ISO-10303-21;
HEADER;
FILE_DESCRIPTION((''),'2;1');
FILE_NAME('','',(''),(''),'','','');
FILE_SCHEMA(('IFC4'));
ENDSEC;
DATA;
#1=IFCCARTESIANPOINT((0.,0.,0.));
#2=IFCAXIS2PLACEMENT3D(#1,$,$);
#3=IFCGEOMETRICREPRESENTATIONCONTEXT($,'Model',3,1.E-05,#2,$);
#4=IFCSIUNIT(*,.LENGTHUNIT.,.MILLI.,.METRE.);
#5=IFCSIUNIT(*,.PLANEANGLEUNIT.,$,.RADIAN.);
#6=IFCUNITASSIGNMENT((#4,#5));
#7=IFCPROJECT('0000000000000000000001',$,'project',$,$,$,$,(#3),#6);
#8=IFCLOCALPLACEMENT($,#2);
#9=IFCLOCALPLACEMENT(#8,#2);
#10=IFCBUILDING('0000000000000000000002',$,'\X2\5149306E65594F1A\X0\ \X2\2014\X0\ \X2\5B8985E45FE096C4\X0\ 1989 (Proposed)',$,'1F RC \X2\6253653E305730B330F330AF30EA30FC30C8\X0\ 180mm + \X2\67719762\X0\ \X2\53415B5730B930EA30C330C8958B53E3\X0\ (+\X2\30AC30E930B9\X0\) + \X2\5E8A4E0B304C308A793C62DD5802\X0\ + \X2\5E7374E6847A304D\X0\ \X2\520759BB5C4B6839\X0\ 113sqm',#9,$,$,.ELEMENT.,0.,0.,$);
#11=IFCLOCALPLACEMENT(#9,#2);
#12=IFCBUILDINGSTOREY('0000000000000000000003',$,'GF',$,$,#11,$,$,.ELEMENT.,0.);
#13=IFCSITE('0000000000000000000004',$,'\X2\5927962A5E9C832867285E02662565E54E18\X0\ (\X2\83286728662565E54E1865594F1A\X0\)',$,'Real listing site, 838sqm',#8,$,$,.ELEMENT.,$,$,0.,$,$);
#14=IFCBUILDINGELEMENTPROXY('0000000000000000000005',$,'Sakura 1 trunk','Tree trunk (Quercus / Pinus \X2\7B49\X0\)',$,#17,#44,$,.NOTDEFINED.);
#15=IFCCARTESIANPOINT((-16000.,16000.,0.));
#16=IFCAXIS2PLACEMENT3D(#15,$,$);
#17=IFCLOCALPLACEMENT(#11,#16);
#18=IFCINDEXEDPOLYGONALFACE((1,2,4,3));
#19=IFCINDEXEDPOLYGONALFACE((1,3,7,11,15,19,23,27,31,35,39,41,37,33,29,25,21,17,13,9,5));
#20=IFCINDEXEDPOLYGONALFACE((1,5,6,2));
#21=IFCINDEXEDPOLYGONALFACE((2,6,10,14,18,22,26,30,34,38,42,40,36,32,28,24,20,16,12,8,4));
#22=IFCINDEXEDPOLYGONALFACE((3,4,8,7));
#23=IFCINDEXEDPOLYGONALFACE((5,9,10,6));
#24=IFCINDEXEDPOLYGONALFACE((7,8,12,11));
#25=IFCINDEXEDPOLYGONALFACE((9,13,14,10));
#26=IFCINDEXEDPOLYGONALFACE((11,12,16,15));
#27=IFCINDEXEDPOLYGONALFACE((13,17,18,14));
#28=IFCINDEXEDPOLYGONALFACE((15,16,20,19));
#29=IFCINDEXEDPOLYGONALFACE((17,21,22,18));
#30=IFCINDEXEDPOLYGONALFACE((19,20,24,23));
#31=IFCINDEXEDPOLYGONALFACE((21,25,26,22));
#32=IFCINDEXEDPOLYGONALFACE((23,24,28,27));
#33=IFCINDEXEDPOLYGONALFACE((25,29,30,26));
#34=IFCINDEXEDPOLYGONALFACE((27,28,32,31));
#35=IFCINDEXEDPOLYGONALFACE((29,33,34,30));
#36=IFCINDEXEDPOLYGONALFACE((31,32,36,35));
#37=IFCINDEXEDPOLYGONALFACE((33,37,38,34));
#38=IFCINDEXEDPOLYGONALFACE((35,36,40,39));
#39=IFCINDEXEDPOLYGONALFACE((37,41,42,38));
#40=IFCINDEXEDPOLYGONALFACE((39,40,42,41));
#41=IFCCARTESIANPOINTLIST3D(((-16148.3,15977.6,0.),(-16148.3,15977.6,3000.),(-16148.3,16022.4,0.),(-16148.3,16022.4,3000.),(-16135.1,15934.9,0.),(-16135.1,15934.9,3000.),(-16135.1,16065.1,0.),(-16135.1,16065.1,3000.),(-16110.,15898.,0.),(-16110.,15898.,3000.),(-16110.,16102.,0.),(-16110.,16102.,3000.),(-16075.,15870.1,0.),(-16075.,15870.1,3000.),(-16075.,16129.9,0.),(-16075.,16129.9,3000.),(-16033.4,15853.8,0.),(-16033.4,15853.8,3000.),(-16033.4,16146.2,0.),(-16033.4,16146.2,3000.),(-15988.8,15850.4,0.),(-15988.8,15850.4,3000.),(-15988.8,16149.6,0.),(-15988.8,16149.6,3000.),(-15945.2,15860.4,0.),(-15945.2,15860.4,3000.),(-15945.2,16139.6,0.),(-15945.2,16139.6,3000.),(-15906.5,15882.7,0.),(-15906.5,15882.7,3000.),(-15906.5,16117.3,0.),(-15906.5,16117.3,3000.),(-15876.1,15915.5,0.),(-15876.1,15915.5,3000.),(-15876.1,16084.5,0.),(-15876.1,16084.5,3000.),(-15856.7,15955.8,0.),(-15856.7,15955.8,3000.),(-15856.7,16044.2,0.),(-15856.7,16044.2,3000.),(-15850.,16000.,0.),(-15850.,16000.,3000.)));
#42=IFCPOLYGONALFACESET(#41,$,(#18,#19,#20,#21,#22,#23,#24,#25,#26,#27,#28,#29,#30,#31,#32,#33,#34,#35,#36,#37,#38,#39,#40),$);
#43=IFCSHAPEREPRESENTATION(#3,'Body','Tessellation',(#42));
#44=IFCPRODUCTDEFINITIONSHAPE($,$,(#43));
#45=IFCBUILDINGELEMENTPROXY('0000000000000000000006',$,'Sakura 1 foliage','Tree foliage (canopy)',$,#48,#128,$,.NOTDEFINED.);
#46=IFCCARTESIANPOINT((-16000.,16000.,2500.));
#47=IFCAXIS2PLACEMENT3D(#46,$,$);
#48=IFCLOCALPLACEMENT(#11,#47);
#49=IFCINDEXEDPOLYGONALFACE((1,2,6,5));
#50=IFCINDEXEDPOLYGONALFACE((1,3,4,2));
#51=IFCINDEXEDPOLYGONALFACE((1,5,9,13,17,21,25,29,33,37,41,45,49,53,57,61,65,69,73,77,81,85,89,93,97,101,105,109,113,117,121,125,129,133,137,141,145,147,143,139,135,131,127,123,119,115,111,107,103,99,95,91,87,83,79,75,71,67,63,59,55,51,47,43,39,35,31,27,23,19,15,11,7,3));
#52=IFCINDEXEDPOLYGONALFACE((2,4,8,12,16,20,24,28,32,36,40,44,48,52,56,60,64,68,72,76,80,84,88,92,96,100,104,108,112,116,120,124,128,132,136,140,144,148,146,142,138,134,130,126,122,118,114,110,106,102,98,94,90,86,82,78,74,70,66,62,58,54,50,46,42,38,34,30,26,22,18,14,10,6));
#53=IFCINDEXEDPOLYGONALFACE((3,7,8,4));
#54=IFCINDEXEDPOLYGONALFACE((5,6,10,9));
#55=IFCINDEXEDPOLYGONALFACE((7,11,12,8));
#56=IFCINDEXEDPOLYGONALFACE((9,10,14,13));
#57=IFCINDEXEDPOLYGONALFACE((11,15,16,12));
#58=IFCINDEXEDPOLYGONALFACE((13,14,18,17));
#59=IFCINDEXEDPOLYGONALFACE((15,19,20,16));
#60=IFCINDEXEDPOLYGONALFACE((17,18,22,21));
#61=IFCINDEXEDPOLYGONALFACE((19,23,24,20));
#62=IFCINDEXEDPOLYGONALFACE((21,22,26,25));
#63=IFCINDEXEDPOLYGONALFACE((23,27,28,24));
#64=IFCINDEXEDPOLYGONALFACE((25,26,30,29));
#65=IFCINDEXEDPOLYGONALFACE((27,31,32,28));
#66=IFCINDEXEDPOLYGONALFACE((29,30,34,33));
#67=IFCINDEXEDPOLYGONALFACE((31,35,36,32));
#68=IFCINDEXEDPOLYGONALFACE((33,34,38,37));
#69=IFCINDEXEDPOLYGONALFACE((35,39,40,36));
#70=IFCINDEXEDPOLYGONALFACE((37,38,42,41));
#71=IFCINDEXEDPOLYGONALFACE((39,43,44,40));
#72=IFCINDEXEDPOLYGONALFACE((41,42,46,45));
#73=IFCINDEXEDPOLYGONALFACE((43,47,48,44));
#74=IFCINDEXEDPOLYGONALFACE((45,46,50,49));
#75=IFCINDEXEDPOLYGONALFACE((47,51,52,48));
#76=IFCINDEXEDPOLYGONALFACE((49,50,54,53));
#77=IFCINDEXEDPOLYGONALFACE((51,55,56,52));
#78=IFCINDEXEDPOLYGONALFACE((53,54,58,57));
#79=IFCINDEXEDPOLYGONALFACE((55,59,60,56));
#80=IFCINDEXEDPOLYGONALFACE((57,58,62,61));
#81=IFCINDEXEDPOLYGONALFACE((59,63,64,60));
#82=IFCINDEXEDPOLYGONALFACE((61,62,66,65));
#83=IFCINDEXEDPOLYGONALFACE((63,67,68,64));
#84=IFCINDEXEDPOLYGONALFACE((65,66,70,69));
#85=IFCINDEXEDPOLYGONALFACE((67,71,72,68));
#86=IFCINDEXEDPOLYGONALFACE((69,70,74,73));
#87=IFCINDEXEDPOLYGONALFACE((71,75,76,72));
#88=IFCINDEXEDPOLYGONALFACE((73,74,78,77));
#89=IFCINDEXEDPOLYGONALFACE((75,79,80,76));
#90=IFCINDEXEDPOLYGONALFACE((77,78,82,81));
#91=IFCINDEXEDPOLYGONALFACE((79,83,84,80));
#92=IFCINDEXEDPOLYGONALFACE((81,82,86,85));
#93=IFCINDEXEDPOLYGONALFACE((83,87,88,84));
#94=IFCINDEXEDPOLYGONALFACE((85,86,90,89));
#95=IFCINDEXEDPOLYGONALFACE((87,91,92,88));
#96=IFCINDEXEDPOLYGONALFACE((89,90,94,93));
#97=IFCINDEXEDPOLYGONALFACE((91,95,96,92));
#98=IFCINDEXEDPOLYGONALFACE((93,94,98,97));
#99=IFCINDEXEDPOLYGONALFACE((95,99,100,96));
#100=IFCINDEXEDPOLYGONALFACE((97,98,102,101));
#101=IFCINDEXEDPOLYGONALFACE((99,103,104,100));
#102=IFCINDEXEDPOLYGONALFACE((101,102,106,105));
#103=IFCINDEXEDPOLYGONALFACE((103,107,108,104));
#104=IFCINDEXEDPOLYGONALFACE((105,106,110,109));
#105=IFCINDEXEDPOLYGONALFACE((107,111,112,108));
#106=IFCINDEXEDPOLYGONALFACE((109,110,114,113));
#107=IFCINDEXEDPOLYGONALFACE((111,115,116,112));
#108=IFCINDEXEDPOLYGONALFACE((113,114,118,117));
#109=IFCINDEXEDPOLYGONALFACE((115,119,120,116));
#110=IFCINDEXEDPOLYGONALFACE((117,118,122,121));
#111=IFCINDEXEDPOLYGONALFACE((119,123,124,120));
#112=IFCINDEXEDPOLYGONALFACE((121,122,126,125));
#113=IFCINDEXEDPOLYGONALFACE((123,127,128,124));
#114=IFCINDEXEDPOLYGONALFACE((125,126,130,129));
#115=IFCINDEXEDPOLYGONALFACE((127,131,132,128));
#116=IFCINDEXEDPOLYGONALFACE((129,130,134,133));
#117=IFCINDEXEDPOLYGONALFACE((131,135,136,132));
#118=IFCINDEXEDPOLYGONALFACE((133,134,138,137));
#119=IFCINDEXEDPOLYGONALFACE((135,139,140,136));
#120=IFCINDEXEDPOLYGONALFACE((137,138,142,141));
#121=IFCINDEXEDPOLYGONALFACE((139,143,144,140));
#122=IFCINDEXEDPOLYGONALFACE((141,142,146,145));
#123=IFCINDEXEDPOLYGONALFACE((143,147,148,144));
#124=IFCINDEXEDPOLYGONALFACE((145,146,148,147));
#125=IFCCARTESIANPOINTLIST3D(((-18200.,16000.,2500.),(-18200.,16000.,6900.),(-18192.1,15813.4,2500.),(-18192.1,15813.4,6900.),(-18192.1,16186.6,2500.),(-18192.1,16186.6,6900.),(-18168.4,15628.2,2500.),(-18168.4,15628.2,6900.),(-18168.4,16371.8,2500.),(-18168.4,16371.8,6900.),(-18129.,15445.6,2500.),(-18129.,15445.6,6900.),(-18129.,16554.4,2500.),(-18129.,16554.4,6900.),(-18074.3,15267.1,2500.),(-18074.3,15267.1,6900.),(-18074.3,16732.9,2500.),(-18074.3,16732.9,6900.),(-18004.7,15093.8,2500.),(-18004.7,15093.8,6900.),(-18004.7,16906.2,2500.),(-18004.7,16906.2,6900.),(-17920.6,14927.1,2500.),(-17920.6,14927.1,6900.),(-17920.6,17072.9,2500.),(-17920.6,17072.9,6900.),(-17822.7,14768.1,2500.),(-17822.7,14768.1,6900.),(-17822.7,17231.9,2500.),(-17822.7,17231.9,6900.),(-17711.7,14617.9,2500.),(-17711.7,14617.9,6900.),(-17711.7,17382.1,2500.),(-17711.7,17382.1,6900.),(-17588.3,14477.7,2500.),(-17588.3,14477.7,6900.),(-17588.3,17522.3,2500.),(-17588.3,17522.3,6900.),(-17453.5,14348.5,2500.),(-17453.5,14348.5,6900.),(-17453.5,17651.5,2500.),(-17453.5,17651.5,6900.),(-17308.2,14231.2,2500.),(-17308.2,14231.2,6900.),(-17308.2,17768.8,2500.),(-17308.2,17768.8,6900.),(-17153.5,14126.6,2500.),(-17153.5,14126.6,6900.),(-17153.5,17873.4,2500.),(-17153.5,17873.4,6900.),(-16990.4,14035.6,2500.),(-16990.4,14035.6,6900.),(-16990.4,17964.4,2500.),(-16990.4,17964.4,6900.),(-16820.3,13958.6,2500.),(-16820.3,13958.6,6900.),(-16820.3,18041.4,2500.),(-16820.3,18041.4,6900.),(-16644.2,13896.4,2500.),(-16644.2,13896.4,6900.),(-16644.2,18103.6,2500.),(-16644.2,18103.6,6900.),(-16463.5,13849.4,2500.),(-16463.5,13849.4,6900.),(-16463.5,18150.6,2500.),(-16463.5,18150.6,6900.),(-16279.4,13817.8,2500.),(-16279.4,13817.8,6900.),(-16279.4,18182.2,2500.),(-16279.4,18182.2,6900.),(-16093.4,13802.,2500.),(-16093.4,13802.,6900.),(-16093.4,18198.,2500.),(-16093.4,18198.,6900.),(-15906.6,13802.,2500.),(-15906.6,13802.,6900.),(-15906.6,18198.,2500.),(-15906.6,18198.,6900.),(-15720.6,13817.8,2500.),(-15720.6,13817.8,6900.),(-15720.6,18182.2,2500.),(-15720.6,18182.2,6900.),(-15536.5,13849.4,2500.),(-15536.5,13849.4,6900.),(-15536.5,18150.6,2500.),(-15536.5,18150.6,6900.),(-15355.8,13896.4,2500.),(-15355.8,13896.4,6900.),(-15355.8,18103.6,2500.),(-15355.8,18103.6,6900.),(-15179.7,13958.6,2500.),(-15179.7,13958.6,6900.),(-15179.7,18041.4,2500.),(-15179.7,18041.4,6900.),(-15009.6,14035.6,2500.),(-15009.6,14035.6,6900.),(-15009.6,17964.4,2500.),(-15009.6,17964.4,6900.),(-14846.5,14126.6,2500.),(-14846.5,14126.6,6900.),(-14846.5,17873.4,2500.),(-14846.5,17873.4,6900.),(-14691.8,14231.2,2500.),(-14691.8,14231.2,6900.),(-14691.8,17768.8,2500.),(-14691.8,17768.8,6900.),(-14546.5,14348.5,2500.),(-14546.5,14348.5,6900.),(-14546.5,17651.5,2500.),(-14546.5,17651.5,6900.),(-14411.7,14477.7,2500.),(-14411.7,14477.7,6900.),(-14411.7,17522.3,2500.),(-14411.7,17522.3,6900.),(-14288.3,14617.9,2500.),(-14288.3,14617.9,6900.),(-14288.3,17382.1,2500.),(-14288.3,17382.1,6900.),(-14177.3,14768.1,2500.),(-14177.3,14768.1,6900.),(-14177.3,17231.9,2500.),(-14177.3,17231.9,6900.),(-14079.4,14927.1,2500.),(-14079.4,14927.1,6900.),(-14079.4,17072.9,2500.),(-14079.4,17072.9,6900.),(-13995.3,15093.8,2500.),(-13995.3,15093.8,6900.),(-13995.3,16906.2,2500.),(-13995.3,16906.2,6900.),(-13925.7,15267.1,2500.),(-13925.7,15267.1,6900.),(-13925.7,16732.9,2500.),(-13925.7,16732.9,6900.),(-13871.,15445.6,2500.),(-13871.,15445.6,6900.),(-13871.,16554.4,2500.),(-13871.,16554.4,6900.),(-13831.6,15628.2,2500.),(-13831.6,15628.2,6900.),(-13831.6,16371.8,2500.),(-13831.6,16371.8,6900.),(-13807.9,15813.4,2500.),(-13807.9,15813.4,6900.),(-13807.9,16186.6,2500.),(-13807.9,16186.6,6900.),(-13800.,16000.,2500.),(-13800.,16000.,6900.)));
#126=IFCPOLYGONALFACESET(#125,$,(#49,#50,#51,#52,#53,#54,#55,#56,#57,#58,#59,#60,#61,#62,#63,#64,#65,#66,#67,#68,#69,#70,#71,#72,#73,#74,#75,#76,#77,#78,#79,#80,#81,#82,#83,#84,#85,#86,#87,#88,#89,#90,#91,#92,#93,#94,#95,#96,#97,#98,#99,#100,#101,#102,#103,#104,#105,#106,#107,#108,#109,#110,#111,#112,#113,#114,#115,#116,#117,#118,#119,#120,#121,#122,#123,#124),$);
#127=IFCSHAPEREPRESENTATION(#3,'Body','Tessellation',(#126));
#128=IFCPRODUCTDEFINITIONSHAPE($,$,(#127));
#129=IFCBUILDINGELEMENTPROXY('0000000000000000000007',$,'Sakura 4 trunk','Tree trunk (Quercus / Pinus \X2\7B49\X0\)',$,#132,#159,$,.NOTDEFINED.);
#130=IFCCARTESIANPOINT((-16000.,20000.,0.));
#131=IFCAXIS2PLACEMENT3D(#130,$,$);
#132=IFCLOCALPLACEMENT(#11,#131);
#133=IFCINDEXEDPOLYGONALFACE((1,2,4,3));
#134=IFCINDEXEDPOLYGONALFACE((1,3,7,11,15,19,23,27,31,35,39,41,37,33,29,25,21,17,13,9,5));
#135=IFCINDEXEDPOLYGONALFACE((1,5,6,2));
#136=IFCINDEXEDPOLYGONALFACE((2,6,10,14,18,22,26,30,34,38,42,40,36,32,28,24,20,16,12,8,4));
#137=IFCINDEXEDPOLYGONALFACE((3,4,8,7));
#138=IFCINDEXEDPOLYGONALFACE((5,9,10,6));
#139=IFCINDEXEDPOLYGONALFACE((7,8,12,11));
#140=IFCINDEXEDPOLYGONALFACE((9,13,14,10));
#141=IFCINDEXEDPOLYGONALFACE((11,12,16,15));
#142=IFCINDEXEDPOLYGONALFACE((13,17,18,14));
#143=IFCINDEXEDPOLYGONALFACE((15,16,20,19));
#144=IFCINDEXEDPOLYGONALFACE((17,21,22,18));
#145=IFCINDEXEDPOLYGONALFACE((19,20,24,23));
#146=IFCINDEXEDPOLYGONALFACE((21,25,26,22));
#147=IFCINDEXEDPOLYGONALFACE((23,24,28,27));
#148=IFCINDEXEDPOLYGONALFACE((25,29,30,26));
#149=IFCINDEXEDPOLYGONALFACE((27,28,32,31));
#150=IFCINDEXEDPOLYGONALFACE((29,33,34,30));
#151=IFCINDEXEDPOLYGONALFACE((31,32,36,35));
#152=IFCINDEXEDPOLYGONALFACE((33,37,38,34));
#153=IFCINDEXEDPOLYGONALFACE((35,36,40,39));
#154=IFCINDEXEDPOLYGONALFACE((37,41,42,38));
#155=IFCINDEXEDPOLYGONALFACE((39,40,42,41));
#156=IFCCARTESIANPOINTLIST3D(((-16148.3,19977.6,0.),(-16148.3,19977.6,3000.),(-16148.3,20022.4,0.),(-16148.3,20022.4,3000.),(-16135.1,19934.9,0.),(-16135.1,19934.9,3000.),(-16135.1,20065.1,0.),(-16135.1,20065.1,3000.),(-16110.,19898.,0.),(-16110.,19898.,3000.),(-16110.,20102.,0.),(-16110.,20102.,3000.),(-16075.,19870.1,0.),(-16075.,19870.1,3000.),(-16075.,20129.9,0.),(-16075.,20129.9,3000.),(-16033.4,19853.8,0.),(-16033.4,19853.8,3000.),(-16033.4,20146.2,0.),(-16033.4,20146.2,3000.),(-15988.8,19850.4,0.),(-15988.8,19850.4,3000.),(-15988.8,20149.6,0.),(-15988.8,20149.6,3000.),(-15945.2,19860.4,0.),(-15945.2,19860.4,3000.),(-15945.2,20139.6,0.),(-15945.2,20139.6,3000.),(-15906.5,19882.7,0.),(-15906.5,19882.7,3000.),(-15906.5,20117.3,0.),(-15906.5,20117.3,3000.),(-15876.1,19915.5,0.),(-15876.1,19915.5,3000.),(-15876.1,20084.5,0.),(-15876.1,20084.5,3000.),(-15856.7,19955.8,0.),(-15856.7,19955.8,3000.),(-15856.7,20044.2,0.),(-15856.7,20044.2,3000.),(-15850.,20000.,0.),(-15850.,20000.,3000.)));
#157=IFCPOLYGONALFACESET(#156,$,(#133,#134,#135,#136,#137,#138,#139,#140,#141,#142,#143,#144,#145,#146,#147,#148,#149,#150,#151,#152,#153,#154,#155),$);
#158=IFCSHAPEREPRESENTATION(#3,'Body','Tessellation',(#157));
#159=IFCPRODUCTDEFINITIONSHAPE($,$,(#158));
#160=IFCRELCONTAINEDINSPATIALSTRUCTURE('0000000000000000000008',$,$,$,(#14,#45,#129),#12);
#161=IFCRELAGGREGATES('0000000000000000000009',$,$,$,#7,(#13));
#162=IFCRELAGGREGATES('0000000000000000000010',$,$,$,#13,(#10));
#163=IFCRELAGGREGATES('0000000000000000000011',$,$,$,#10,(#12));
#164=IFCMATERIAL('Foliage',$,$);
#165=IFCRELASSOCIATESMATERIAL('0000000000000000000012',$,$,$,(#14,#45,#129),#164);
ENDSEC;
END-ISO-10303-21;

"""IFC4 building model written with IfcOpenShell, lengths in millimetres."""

from ifc_helpers import new_model, si_unit, frame, origin, origin_2d, place, context, project, spatial, circle, extrude, material, element, save


model = new_model("IFC4")

# Units and contexts
model_context = context("Model", 3, precision=1e-05, world=origin())
ifc_project = project(units=[si_unit("LENGTHUNIT", "METRE", prefix="MILLI"), si_unit("PLANEANGLEUNIT", "RADIAN")], contexts=[model_context])

# Site, building, storey
site_placement = place(None, origin())
site = spatial("IfcSite", under=ifc_project, at=site_placement, Name="大阪府茨木市春日丘 (茨木春日丘教会)", ObjectType="Real listing site, 838sqm", CompositionType="ELEMENT", RefElevation=0.0)
building_placement = place(site_placement, origin())
building = spatial("IfcBuilding", under=site, at=building_placement, Name="光の教会 — 安藤忠雄 1989 (Proposed)", ObjectType="1F RC 打放しコンクリート 180mm + 東面 十字スリット開口 (+ガラス) + 床下がり礼拝堂 + 平瓦葺き 切妻屋根 113sqm", CompositionType="ELEMENT", ElevationOfRefHeight=0.0, ElevationOfTerrain=0.0)
storey_placement = place(building_placement, origin())
storey = spatial("IfcBuildingStorey", under=building, at=storey_placement, Name="GF", CompositionType="ELEMENT", Elevation=0.0)

# Building element proxies
ifc_material_1 = material(Name="Foliage")
proxy_1_placement = place(storey_placement, frame((-16000.0, 16000.0, 0.0)))
element("IfcBuildingElementProxy", 1, at=proxy_1_placement, inside=storey, material=ifc_material_1, Name="Sakura 1 trunk", Description="Tree trunk (Quercus / Pinus 等)", PredefinedType="NOTDEFINED", context=model_context, shape_type="SweptSolid", body=[
    extrude(circle(Radius=150.0, at=origin_2d()), frame((-16000.0, 16000.0, 0.0)), (0.0, 0.0, 1.0), 3000.0),
])
proxy_2_placement = place(storey_placement, frame((-16000.0, 16000.0, 2500.0)))
element("IfcBuildingElementProxy", 2, at=proxy_2_placement, inside=storey, material=ifc_material_1, Name="Sakura 1 foliage", Description="Tree foliage (canopy)", PredefinedType="NOTDEFINED", context=model_context, shape_type="SweptSolid", body=[
    extrude(circle(Radius=2200.0, at=origin_2d()), frame((-16000.0, 16000.0, 2500.0)), (0.0, 0.0, 1.0), 4400.0),
])
proxy_3_placement = place(storey_placement, frame((-16000.0, 20000.0, 0.0)))
element("IfcBuildingElementProxy", 3, at=proxy_3_placement, inside=storey, material=ifc_material_1, Name="Sakura 4 trunk", Description="Tree trunk (Quercus / Pinus 等)", PredefinedType="NOTDEFINED", context=model_context, shape_type="SweptSolid", body=[
    extrude(circle(Radius=150.0, at=origin_2d()), frame((-16000.0, 20000.0, 0.0)), (0.0, 0.0, 1.0), 3000.0),
])

save(model, "model.ifc")
